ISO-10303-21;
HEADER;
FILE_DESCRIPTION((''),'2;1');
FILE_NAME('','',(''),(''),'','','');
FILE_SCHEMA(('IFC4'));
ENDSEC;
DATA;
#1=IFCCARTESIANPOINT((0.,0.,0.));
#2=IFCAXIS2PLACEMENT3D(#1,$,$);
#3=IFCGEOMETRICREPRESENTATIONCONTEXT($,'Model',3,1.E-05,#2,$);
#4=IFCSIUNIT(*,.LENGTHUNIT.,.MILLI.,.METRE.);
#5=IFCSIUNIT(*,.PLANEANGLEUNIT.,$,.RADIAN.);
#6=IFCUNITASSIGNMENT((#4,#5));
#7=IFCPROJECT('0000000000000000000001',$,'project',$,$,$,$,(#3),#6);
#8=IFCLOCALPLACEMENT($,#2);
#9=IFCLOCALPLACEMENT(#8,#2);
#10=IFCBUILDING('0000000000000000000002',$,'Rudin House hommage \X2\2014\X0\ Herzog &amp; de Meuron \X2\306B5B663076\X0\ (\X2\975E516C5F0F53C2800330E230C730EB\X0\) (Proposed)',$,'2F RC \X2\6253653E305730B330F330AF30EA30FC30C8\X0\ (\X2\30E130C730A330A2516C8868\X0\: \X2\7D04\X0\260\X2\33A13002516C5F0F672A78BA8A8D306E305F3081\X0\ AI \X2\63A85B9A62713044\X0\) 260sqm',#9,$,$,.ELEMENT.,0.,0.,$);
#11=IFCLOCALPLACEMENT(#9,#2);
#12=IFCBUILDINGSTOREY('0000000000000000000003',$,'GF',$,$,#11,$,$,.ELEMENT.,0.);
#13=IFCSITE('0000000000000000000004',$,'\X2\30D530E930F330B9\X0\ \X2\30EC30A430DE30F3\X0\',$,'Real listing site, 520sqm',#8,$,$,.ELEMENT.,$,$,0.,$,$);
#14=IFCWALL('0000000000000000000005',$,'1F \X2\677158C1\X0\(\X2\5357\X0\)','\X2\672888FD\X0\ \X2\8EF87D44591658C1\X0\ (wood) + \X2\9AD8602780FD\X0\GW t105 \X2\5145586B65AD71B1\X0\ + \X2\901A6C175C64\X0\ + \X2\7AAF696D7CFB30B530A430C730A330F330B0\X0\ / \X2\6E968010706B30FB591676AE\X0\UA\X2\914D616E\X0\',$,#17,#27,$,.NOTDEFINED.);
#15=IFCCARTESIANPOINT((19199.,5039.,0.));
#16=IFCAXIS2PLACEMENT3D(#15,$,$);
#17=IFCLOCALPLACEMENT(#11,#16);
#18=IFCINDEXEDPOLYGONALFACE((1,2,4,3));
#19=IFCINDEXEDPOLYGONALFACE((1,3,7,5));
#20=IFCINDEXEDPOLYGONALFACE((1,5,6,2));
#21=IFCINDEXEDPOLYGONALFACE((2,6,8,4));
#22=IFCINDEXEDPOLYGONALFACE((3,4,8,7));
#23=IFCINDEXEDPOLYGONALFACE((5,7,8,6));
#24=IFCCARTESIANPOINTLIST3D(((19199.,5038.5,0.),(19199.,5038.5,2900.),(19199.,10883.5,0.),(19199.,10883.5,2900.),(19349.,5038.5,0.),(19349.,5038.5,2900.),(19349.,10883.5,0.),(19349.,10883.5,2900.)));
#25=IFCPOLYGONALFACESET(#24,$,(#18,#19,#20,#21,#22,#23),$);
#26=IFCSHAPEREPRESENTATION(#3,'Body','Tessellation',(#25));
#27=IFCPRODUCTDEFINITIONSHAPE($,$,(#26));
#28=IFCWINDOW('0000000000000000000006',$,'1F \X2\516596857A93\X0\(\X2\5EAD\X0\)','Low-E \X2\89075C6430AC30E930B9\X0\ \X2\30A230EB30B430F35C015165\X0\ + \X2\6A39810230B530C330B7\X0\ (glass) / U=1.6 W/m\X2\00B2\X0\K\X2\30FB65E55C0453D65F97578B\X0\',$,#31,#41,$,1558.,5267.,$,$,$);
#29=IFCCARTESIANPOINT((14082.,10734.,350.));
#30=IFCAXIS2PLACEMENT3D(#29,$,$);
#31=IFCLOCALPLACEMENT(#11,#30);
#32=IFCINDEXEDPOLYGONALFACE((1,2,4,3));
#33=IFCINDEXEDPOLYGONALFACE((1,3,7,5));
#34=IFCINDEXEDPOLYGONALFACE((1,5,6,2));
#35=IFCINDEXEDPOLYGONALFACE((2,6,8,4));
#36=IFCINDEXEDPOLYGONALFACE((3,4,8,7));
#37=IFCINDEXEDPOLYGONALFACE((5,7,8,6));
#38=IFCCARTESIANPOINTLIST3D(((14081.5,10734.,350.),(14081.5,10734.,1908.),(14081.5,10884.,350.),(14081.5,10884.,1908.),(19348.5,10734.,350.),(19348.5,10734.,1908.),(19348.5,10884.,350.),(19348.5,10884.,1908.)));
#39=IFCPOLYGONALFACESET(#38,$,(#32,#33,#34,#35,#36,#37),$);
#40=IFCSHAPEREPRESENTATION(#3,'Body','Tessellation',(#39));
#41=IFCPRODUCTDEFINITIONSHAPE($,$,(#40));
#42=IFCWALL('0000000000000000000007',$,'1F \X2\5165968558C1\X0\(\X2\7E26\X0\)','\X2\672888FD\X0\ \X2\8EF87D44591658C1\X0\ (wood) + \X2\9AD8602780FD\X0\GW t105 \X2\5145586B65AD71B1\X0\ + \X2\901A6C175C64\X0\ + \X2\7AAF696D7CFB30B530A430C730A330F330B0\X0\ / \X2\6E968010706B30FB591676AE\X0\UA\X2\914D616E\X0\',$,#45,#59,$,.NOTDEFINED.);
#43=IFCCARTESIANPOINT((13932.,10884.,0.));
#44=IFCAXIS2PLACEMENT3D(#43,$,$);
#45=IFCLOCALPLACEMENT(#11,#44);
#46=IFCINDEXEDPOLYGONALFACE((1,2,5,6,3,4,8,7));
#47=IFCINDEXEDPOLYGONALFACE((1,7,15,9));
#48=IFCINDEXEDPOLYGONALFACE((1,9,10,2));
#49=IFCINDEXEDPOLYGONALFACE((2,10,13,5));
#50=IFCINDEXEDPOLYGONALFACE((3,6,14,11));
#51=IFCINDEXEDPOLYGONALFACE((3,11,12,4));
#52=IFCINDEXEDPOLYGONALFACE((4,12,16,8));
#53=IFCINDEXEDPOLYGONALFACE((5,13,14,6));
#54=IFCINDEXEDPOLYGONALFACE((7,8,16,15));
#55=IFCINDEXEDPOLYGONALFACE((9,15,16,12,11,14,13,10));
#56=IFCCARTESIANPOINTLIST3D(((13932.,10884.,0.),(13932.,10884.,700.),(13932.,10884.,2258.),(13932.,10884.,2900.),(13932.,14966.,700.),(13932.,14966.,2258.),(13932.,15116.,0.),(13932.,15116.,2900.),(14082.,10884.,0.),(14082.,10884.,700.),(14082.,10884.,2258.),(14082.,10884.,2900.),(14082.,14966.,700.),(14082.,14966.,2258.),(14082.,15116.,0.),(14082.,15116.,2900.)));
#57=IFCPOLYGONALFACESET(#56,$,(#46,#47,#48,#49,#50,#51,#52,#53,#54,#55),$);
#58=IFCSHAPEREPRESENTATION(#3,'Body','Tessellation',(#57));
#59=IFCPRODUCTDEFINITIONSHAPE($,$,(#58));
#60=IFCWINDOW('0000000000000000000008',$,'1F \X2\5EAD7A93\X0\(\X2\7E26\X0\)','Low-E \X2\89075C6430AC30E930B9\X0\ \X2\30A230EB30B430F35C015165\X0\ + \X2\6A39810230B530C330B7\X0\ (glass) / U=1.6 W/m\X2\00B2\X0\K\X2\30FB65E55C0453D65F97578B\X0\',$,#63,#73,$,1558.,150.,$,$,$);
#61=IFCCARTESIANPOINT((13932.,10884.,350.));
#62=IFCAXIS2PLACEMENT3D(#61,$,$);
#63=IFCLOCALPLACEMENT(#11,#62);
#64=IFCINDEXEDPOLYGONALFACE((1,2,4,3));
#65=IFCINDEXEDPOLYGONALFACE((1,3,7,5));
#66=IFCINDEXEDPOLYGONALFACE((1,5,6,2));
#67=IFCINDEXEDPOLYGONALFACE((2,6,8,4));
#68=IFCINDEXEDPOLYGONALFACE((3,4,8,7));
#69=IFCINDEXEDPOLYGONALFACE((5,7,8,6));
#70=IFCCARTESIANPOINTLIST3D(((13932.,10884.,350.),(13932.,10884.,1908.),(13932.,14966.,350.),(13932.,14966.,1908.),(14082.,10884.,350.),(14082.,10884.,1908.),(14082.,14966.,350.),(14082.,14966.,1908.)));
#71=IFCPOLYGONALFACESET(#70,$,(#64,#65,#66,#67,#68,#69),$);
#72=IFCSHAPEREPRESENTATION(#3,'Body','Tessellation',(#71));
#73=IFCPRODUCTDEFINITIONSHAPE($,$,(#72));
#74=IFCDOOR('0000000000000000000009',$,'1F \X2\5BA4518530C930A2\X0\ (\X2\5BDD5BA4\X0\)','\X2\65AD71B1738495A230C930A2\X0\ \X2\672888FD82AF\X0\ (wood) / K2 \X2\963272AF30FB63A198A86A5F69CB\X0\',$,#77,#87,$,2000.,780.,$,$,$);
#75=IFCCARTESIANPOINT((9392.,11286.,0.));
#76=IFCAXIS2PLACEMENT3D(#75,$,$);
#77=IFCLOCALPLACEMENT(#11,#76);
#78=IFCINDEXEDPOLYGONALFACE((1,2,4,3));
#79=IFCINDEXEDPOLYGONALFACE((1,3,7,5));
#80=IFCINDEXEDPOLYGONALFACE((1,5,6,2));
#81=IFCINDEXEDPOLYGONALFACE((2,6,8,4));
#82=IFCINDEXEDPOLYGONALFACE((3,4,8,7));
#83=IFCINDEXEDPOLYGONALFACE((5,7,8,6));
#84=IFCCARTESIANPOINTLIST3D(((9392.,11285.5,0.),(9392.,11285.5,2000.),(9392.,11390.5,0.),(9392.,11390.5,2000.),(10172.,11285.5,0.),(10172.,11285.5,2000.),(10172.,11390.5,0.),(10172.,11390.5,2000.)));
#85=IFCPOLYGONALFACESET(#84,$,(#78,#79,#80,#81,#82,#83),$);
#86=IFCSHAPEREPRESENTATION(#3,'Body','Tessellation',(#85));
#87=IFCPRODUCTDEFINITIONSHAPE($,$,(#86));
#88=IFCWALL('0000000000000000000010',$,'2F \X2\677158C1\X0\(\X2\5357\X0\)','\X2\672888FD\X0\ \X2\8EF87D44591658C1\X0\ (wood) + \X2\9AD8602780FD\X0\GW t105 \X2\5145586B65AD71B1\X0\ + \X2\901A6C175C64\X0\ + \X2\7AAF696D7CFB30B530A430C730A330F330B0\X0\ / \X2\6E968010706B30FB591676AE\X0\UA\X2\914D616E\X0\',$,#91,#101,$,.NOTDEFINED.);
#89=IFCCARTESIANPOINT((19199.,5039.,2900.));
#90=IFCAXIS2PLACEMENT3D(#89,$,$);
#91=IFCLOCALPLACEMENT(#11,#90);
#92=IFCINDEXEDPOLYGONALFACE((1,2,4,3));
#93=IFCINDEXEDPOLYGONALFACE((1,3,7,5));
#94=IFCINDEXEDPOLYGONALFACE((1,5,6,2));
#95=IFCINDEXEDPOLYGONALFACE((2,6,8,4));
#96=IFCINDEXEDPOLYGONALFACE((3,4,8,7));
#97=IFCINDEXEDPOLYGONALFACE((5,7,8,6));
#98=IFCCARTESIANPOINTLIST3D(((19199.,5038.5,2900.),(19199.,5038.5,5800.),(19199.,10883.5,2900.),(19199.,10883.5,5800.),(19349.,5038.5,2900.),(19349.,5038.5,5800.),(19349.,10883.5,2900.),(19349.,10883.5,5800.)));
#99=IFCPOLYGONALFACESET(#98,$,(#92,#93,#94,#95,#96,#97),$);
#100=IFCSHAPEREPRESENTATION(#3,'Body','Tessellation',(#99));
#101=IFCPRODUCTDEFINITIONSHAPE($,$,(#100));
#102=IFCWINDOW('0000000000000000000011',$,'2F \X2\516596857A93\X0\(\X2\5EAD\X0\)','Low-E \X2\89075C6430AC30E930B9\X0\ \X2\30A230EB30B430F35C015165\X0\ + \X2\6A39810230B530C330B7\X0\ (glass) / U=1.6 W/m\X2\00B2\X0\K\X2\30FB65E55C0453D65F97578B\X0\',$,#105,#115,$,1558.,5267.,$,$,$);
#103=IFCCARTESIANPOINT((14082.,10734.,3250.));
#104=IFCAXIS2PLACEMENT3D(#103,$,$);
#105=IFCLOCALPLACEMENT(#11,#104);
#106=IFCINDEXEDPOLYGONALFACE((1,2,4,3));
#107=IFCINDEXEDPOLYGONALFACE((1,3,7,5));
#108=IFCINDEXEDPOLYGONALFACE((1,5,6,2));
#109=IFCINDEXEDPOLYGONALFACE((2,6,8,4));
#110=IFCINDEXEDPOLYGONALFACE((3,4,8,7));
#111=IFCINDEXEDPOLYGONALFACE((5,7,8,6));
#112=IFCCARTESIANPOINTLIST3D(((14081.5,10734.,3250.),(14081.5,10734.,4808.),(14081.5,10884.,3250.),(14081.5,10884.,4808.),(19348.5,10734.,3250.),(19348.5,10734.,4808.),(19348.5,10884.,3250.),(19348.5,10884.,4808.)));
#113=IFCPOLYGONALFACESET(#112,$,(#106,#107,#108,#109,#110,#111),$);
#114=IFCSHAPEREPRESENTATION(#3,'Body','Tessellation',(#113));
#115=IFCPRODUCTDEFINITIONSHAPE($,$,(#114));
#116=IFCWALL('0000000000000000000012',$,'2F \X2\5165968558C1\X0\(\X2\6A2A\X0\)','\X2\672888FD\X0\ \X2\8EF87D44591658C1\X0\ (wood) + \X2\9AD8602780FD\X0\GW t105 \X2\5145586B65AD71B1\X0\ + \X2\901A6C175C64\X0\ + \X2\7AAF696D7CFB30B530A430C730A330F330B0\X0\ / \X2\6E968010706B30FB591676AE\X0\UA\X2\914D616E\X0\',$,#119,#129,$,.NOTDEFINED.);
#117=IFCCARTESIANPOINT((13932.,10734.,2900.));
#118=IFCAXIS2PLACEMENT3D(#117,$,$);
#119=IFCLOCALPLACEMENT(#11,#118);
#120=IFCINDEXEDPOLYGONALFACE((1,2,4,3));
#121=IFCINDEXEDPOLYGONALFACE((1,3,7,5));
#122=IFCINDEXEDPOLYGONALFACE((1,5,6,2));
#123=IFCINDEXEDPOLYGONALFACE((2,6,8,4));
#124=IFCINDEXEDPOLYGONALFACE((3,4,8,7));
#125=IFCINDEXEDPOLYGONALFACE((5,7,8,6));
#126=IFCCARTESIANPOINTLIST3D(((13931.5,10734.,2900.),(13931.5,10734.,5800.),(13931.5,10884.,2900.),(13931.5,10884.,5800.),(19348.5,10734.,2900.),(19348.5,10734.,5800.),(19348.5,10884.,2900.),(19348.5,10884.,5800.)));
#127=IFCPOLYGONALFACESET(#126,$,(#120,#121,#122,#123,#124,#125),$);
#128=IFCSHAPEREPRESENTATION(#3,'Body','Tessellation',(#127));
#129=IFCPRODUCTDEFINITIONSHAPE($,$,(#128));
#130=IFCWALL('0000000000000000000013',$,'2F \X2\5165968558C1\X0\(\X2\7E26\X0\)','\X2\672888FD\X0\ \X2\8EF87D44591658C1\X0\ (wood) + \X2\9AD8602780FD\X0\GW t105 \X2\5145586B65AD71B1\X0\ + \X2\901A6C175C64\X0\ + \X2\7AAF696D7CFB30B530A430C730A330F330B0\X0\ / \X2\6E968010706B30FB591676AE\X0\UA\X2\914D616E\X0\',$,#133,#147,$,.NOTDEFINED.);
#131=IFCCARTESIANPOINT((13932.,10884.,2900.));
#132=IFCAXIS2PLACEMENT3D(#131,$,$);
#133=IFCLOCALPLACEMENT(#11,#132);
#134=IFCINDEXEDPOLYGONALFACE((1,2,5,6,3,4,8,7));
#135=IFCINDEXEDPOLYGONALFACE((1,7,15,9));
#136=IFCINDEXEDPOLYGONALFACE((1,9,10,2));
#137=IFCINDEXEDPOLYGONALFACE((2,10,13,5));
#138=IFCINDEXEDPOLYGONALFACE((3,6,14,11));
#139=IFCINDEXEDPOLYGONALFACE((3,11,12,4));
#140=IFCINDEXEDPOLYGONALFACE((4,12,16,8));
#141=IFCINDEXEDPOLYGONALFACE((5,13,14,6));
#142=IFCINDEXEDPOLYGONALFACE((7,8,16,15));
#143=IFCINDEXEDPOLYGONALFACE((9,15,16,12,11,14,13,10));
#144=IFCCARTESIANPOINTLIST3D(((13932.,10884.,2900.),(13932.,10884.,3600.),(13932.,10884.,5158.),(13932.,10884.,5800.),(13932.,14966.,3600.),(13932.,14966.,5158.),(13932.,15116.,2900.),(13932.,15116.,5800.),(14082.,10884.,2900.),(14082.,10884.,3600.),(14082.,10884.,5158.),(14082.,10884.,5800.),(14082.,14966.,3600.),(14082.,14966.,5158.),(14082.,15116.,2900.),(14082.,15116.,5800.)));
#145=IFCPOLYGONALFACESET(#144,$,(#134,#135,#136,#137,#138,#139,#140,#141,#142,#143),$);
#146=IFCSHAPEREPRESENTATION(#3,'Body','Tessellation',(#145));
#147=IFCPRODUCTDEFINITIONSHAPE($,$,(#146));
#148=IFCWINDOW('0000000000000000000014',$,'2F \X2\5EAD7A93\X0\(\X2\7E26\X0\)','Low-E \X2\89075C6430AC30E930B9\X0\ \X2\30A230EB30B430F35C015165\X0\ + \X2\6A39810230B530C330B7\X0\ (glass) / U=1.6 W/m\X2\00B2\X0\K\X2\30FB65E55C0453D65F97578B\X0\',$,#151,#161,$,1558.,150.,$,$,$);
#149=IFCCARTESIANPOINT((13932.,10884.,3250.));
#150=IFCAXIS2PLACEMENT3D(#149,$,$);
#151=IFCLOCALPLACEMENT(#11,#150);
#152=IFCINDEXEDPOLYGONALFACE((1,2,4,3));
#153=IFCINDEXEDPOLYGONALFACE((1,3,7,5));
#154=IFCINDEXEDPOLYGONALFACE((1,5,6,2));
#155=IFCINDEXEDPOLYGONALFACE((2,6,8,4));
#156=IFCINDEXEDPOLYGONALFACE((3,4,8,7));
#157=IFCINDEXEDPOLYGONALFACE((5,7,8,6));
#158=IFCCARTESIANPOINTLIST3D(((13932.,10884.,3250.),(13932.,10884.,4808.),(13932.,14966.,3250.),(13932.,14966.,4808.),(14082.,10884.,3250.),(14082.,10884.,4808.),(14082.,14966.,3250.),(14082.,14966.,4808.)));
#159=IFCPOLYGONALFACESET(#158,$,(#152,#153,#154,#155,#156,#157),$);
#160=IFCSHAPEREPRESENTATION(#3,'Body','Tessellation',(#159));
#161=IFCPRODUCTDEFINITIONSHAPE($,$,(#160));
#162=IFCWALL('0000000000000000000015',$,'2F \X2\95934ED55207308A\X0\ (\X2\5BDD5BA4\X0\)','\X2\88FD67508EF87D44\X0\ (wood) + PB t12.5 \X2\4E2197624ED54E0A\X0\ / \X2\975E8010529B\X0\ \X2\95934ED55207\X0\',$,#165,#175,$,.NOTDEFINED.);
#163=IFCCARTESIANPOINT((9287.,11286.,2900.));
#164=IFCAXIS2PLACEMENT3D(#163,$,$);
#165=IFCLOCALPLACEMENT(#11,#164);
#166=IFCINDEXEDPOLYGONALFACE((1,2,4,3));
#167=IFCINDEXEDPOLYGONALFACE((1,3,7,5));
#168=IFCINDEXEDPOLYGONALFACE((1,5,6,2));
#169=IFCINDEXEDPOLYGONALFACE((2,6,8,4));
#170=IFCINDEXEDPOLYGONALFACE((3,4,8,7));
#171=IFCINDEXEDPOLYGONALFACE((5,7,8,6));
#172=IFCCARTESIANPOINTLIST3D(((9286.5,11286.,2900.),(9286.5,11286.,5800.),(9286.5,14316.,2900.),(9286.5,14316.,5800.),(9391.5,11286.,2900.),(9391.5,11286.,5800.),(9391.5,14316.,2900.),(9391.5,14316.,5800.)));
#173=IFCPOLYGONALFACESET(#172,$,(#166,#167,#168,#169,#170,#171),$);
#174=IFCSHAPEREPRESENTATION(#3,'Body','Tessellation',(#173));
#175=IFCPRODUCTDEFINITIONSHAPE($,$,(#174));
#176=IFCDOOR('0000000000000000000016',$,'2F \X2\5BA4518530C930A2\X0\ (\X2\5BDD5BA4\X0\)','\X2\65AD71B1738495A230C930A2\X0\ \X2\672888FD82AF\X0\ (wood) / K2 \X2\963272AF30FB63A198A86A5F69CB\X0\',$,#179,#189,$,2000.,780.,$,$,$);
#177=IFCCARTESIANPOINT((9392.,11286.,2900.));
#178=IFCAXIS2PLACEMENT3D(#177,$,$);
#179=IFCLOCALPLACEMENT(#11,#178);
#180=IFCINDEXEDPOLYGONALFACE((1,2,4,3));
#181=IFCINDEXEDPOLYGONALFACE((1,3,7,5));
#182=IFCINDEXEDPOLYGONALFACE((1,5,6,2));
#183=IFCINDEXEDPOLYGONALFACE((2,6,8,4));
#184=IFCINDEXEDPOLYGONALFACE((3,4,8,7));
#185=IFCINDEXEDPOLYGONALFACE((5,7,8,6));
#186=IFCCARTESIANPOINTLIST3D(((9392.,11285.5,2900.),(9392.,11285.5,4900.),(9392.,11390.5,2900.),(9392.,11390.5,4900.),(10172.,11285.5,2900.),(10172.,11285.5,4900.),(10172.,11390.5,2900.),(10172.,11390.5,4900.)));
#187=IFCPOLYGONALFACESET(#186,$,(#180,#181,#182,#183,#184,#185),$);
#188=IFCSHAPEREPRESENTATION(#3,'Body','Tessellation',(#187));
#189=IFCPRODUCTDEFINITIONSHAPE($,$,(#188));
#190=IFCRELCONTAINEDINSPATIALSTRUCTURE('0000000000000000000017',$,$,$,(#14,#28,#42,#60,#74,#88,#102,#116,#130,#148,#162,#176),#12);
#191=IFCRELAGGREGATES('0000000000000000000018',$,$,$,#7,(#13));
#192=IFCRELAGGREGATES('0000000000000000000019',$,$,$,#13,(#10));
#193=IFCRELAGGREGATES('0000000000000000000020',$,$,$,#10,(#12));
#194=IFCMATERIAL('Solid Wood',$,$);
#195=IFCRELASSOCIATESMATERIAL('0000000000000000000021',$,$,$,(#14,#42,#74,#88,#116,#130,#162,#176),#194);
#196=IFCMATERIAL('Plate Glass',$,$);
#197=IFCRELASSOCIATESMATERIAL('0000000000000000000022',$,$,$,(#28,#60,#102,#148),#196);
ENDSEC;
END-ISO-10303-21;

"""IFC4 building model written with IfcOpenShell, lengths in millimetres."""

from ifc_helpers import new_model, si_unit, frame, frame_2d, origin, place, context, project, spatial, rectangle, extrude, material, element, fill, save


model = new_model("IFC4")

# Units and contexts
model_context = context("Model", 3, precision=1e-05, world=origin())
ifc_project = project(units=[si_unit("LENGTHUNIT", "METRE", prefix="MILLI"), si_unit("PLANEANGLEUNIT", "RADIAN")], contexts=[model_context])

# Site, building, storey
site_placement = place(None, origin())
site = spatial("IfcSite", under=ifc_project, at=site_placement, Name="フランス レイマン", ObjectType="Real listing site, 520sqm", CompositionType="ELEMENT", RefElevation=0.0)
building_placement = place(site_placement, origin())
building = spatial("IfcBuilding", under=site, at=building_placement, Name="Rudin House hommage — Herzog &amp; de Meuron に学ぶ (非公式参考モデル) (Proposed)", ObjectType="2F RC 打放しコンクリート (メディア公表: 約260㎡。公式未確認のため AI 推定扱い) 260sqm", CompositionType="ELEMENT", ElevationOfRefHeight=0.0, ElevationOfTerrain=0.0)
storey_placement = place(building_placement, origin())
storey = spatial("IfcBuildingStorey", under=building, at=storey_placement, Name="GF", CompositionType="ELEMENT", Elevation=0.0)

# Shared definitions
ifc_material_1 = material(Name="Solid Wood")

# Wall, opening, window
wall_1_placement = place(storey_placement, frame((19199.0, 5039.0, 0.0)))
wall_1 = element("IfcWall", 1, at=wall_1_placement, inside=storey, material=ifc_material_1, Name="1F 東壁(南)", Description="木製 軸組外壁 (wood) + 高性能GW t105 充填断熱 + 通気層 + 窯業系サイディング / 準耐火・外皮UA配慮", PredefinedType="NOTDEFINED", context=model_context, shape_type="SweptSolid", body=[
    extrude(rectangle(XDim=150.0, YDim=5845.0, at=frame_2d((75.0, 2922.0))), frame((19199.0, 5039.0, 0.0)), (0.0, 0.0, 1.0), 2900.0),
])
opening_1_placement = place(storey_placement, frame((14082.0, 10734.0, 350.0)))
opening_1 = element("IfcOpeningElement", 2, at=opening_1_placement, cuts=wall_1, PredefinedType="NOTDEFINED", context=model_context, shape_type="SweptSolid", body=[
    extrude(rectangle(XDim=5267.0, YDim=150.0, at=frame_2d((2633.0, 75.0))), frame((14082.0, 10734.0, 350.0)), (0.0, 0.0, 1.0), 1558.0),
])
ifc_material_2 = material(Name="Plate Glass")
window_1_placement = place(storey_placement, frame((14082.0, 10734.0, 350.0)))
window_1 = element("IfcWindow", 3, at=window_1_placement, inside=storey, material=ifc_material_2, Name="1F 入隅窓(庭)", Description="Low-E 複層ガラス アルゴン封入 + 樹脂サッシ (glass) / U=1.6 W/m²K・日射取得型", OverallHeight=1558.0, OverallWidth=5267.0, context=model_context, shape_type="SweptSolid", body=[
    extrude(rectangle(XDim=5267.0, YDim=150.0, at=frame_2d((2633.0, 75.0))), frame((14082.0, 10734.0, 350.0)), (0.0, 0.0, 1.0), 1558.0),
])
fill(opening_1, window_1)

# Wall, opening, window
wall_2_placement = place(storey_placement, frame((13932.0, 10884.0, 0.0)))
wall_2 = element("IfcWall", 4, at=wall_2_placement, inside=storey, material=ifc_material_1, Name="1F 入隅壁(縦)", Description="木製 軸組外壁 (wood) + 高性能GW t105 充填断熱 + 通気層 + 窯業系サイディング / 準耐火・外皮UA配慮", PredefinedType="NOTDEFINED", context=model_context, shape_type="SweptSolid", body=[
    extrude(rectangle(XDim=150.0, YDim=4232.0, at=frame_2d((75.0, 2116.0))), frame((13932.0, 10884.0, 0.0)), (0.0, 0.0, 1.0), 2900.0),
])
opening_2_placement = place(storey_placement, frame((13932.0, 10884.0, 350.0)))
opening_2 = element("IfcOpeningElement", 5, at=opening_2_placement, cuts=wall_2, PredefinedType="NOTDEFINED", context=model_context, shape_type="SweptSolid", body=[
    extrude(rectangle(XDim=150.0, YDim=4082.0, at=frame_2d((75.0, 2041.0))), frame((13932.0, 10884.0, 350.0)), (0.0, 0.0, 1.0), 1558.0),
])
window_2_placement = place(storey_placement, frame((13932.0, 10884.0, 350.0)))
window_2 = element("IfcWindow", 6, at=window_2_placement, inside=storey, material=ifc_material_2, Name="1F 庭窓(縦)", Description="Low-E 複層ガラス アルゴン封入 + 樹脂サッシ (glass) / U=1.6 W/m²K・日射取得型", OverallHeight=1558.0, OverallWidth=150.0, context=model_context, shape_type="SweptSolid", body=[
    extrude(rectangle(XDim=150.0, YDim=4082.0, at=frame_2d((75.0, 2041.0))), frame((13932.0, 10884.0, 350.0)), (0.0, 0.0, 1.0), 1558.0),
])
fill(opening_2, window_2)

# Door
door_1_placement = place(storey_placement, frame((9392.0, 11286.0, 0.0)))
element("IfcDoor", 7, at=door_1_placement, inside=storey, material=ifc_material_1, Name="1F 室内ドア (寝室)", Description="断熱玄関ドア 木製芯 (wood) / K2 防犯・採風機構", OverallHeight=2000.0, OverallWidth=780.0, context=model_context, shape_type="SweptSolid", body=[
    extrude(rectangle(XDim=780.0, YDim=105.0, at=frame_2d((390.0, 52.0))), frame((9392.0, 11286.0, 0.0)), (0.0, 0.0, 1.0), 2000.0),
])

# Wall, opening, window
wall_3_placement = place(storey_placement, frame((19199.0, 5039.0, 2900.0)))
wall_3 = element("IfcWall", 8, at=wall_3_placement, inside=storey, material=ifc_material_1, Name="2F 東壁(南)", Description="木製 軸組外壁 (wood) + 高性能GW t105 充填断熱 + 通気層 + 窯業系サイディング / 準耐火・外皮UA配慮", PredefinedType="NOTDEFINED", context=model_context, shape_type="SweptSolid", body=[
    extrude(rectangle(XDim=150.0, YDim=5845.0, at=frame_2d((75.0, 2922.0))), frame((19199.0, 5039.0, 2900.0)), (0.0, 0.0, 1.0), 2900.0),
])
opening_3_placement = place(storey_placement, frame((14082.0, 10734.0, 3250.0)))
opening_3 = element("IfcOpeningElement", 9, at=opening_3_placement, cuts=wall_3, PredefinedType="NOTDEFINED", context=model_context, shape_type="SweptSolid", body=[
    extrude(rectangle(XDim=5267.0, YDim=150.0, at=frame_2d((2633.0, 75.0))), frame((14082.0, 10734.0, 3250.0)), (0.0, 0.0, 1.0), 1558.0),
])
window_3_placement = place(storey_placement, frame((14082.0, 10734.0, 3250.0)))
window_3 = element("IfcWindow", 10, at=window_3_placement, inside=storey, material=ifc_material_2, Name="2F 入隅窓(庭)", Description="Low-E 複層ガラス アルゴン封入 + 樹脂サッシ (glass) / U=1.6 W/m²K・日射取得型", OverallHeight=1558.0, OverallWidth=5267.0, context=model_context, shape_type="SweptSolid", body=[
    extrude(rectangle(XDim=5267.0, YDim=150.0, at=frame_2d((2633.0, 75.0))), frame((14082.0, 10734.0, 3250.0)), (0.0, 0.0, 1.0), 1558.0),
])
fill(opening_3, window_3)

# Wall
wall_4_placement = place(storey_placement, frame((13932.0, 10734.0, 2900.0)))
element("IfcWall", 11, at=wall_4_placement, inside=storey, material=ifc_material_1, Name="2F 入隅壁(横)", Description="木製 軸組外壁 (wood) + 高性能GW t105 充填断熱 + 通気層 + 窯業系サイディング / 準耐火・外皮UA配慮", PredefinedType="NOTDEFINED", context=model_context, shape_type="SweptSolid", body=[
    extrude(rectangle(XDim=5417.0, YDim=150.0, at=frame_2d((2708.0, 75.0))), frame((13932.0, 10734.0, 2900.0)), (0.0, 0.0, 1.0), 2900.0),
])

# Wall, opening, window
wall_5_placement = place(storey_placement, frame((13932.0, 10884.0, 2900.0)))
wall_5 = element("IfcWall", 12, at=wall_5_placement, inside=storey, material=ifc_material_1, Name="2F 入隅壁(縦)", Description="木製 軸組外壁 (wood) + 高性能GW t105 充填断熱 + 通気層 + 窯業系サイディング / 準耐火・外皮UA配慮", PredefinedType="NOTDEFINED", context=model_context, shape_type="SweptSolid", body=[
    extrude(rectangle(XDim=150.0, YDim=4232.0, at=frame_2d((75.0, 2116.0))), frame((13932.0, 10884.0, 2900.0)), (0.0, 0.0, 1.0), 2900.0),
])
opening_4_placement = place(storey_placement, frame((13932.0, 10884.0, 3250.0)))
opening_4 = element("IfcOpeningElement", 13, at=opening_4_placement, cuts=wall_5, PredefinedType="NOTDEFINED", context=model_context, shape_type="SweptSolid", body=[
    extrude(rectangle(XDim=150.0, YDim=4082.0, at=frame_2d((75.0, 2041.0))), frame((13932.0, 10884.0, 3250.0)), (0.0, 0.0, 1.0), 1558.0),
])
window_4_placement = place(storey_placement, frame((13932.0, 10884.0, 3250.0)))
window_4 = element("IfcWindow", 14, at=window_4_placement, inside=storey, material=ifc_material_2, Name="2F 庭窓(縦)", Description="Low-E 複層ガラス アルゴン封入 + 樹脂サッシ (glass) / U=1.6 W/m²K・日射取得型", OverallHeight=1558.0, OverallWidth=150.0, context=model_context, shape_type="SweptSolid", body=[
    extrude(rectangle(XDim=150.0, YDim=4082.0, at=frame_2d((75.0, 2041.0))), frame((13932.0, 10884.0, 3250.0)), (0.0, 0.0, 1.0), 1558.0),
])
fill(opening_4, window_4)

# Wall
wall_6_placement = place(storey_placement, frame((9287.0, 11286.0, 2900.0)))
element("IfcWall", 15, at=wall_6_placement, inside=storey, material=ifc_material_1, Name="2F 間仕切り (寝室)", Description="製材軸組 (wood) + PB t12.5 両面仕上 / 非耐力 間仕切", PredefinedType="NOTDEFINED", context=model_context, shape_type="SweptSolid", body=[
    extrude(rectangle(XDim=105.0, YDim=3030.0, at=frame_2d((52.0, 1515.0))), frame((9287.0, 11286.0, 2900.0)), (0.0, 0.0, 1.0), 2900.0),
])

# Door
door_2_placement = place(storey_placement, frame((9392.0, 11286.0, 2900.0)))
element("IfcDoor", 16, at=door_2_placement, inside=storey, material=ifc_material_1, Name="2F 室内ドア (寝室)", Description="断熱玄関ドア 木製芯 (wood) / K2 防犯・採風機構", OverallHeight=2000.0, OverallWidth=780.0, context=model_context, shape_type="SweptSolid", body=[
    extrude(rectangle(XDim=780.0, YDim=105.0, at=frame_2d((390.0, 52.0))), frame((9392.0, 11286.0, 2900.0)), (0.0, 0.0, 1.0), 2000.0),
])

save(model, "model.ifc")
